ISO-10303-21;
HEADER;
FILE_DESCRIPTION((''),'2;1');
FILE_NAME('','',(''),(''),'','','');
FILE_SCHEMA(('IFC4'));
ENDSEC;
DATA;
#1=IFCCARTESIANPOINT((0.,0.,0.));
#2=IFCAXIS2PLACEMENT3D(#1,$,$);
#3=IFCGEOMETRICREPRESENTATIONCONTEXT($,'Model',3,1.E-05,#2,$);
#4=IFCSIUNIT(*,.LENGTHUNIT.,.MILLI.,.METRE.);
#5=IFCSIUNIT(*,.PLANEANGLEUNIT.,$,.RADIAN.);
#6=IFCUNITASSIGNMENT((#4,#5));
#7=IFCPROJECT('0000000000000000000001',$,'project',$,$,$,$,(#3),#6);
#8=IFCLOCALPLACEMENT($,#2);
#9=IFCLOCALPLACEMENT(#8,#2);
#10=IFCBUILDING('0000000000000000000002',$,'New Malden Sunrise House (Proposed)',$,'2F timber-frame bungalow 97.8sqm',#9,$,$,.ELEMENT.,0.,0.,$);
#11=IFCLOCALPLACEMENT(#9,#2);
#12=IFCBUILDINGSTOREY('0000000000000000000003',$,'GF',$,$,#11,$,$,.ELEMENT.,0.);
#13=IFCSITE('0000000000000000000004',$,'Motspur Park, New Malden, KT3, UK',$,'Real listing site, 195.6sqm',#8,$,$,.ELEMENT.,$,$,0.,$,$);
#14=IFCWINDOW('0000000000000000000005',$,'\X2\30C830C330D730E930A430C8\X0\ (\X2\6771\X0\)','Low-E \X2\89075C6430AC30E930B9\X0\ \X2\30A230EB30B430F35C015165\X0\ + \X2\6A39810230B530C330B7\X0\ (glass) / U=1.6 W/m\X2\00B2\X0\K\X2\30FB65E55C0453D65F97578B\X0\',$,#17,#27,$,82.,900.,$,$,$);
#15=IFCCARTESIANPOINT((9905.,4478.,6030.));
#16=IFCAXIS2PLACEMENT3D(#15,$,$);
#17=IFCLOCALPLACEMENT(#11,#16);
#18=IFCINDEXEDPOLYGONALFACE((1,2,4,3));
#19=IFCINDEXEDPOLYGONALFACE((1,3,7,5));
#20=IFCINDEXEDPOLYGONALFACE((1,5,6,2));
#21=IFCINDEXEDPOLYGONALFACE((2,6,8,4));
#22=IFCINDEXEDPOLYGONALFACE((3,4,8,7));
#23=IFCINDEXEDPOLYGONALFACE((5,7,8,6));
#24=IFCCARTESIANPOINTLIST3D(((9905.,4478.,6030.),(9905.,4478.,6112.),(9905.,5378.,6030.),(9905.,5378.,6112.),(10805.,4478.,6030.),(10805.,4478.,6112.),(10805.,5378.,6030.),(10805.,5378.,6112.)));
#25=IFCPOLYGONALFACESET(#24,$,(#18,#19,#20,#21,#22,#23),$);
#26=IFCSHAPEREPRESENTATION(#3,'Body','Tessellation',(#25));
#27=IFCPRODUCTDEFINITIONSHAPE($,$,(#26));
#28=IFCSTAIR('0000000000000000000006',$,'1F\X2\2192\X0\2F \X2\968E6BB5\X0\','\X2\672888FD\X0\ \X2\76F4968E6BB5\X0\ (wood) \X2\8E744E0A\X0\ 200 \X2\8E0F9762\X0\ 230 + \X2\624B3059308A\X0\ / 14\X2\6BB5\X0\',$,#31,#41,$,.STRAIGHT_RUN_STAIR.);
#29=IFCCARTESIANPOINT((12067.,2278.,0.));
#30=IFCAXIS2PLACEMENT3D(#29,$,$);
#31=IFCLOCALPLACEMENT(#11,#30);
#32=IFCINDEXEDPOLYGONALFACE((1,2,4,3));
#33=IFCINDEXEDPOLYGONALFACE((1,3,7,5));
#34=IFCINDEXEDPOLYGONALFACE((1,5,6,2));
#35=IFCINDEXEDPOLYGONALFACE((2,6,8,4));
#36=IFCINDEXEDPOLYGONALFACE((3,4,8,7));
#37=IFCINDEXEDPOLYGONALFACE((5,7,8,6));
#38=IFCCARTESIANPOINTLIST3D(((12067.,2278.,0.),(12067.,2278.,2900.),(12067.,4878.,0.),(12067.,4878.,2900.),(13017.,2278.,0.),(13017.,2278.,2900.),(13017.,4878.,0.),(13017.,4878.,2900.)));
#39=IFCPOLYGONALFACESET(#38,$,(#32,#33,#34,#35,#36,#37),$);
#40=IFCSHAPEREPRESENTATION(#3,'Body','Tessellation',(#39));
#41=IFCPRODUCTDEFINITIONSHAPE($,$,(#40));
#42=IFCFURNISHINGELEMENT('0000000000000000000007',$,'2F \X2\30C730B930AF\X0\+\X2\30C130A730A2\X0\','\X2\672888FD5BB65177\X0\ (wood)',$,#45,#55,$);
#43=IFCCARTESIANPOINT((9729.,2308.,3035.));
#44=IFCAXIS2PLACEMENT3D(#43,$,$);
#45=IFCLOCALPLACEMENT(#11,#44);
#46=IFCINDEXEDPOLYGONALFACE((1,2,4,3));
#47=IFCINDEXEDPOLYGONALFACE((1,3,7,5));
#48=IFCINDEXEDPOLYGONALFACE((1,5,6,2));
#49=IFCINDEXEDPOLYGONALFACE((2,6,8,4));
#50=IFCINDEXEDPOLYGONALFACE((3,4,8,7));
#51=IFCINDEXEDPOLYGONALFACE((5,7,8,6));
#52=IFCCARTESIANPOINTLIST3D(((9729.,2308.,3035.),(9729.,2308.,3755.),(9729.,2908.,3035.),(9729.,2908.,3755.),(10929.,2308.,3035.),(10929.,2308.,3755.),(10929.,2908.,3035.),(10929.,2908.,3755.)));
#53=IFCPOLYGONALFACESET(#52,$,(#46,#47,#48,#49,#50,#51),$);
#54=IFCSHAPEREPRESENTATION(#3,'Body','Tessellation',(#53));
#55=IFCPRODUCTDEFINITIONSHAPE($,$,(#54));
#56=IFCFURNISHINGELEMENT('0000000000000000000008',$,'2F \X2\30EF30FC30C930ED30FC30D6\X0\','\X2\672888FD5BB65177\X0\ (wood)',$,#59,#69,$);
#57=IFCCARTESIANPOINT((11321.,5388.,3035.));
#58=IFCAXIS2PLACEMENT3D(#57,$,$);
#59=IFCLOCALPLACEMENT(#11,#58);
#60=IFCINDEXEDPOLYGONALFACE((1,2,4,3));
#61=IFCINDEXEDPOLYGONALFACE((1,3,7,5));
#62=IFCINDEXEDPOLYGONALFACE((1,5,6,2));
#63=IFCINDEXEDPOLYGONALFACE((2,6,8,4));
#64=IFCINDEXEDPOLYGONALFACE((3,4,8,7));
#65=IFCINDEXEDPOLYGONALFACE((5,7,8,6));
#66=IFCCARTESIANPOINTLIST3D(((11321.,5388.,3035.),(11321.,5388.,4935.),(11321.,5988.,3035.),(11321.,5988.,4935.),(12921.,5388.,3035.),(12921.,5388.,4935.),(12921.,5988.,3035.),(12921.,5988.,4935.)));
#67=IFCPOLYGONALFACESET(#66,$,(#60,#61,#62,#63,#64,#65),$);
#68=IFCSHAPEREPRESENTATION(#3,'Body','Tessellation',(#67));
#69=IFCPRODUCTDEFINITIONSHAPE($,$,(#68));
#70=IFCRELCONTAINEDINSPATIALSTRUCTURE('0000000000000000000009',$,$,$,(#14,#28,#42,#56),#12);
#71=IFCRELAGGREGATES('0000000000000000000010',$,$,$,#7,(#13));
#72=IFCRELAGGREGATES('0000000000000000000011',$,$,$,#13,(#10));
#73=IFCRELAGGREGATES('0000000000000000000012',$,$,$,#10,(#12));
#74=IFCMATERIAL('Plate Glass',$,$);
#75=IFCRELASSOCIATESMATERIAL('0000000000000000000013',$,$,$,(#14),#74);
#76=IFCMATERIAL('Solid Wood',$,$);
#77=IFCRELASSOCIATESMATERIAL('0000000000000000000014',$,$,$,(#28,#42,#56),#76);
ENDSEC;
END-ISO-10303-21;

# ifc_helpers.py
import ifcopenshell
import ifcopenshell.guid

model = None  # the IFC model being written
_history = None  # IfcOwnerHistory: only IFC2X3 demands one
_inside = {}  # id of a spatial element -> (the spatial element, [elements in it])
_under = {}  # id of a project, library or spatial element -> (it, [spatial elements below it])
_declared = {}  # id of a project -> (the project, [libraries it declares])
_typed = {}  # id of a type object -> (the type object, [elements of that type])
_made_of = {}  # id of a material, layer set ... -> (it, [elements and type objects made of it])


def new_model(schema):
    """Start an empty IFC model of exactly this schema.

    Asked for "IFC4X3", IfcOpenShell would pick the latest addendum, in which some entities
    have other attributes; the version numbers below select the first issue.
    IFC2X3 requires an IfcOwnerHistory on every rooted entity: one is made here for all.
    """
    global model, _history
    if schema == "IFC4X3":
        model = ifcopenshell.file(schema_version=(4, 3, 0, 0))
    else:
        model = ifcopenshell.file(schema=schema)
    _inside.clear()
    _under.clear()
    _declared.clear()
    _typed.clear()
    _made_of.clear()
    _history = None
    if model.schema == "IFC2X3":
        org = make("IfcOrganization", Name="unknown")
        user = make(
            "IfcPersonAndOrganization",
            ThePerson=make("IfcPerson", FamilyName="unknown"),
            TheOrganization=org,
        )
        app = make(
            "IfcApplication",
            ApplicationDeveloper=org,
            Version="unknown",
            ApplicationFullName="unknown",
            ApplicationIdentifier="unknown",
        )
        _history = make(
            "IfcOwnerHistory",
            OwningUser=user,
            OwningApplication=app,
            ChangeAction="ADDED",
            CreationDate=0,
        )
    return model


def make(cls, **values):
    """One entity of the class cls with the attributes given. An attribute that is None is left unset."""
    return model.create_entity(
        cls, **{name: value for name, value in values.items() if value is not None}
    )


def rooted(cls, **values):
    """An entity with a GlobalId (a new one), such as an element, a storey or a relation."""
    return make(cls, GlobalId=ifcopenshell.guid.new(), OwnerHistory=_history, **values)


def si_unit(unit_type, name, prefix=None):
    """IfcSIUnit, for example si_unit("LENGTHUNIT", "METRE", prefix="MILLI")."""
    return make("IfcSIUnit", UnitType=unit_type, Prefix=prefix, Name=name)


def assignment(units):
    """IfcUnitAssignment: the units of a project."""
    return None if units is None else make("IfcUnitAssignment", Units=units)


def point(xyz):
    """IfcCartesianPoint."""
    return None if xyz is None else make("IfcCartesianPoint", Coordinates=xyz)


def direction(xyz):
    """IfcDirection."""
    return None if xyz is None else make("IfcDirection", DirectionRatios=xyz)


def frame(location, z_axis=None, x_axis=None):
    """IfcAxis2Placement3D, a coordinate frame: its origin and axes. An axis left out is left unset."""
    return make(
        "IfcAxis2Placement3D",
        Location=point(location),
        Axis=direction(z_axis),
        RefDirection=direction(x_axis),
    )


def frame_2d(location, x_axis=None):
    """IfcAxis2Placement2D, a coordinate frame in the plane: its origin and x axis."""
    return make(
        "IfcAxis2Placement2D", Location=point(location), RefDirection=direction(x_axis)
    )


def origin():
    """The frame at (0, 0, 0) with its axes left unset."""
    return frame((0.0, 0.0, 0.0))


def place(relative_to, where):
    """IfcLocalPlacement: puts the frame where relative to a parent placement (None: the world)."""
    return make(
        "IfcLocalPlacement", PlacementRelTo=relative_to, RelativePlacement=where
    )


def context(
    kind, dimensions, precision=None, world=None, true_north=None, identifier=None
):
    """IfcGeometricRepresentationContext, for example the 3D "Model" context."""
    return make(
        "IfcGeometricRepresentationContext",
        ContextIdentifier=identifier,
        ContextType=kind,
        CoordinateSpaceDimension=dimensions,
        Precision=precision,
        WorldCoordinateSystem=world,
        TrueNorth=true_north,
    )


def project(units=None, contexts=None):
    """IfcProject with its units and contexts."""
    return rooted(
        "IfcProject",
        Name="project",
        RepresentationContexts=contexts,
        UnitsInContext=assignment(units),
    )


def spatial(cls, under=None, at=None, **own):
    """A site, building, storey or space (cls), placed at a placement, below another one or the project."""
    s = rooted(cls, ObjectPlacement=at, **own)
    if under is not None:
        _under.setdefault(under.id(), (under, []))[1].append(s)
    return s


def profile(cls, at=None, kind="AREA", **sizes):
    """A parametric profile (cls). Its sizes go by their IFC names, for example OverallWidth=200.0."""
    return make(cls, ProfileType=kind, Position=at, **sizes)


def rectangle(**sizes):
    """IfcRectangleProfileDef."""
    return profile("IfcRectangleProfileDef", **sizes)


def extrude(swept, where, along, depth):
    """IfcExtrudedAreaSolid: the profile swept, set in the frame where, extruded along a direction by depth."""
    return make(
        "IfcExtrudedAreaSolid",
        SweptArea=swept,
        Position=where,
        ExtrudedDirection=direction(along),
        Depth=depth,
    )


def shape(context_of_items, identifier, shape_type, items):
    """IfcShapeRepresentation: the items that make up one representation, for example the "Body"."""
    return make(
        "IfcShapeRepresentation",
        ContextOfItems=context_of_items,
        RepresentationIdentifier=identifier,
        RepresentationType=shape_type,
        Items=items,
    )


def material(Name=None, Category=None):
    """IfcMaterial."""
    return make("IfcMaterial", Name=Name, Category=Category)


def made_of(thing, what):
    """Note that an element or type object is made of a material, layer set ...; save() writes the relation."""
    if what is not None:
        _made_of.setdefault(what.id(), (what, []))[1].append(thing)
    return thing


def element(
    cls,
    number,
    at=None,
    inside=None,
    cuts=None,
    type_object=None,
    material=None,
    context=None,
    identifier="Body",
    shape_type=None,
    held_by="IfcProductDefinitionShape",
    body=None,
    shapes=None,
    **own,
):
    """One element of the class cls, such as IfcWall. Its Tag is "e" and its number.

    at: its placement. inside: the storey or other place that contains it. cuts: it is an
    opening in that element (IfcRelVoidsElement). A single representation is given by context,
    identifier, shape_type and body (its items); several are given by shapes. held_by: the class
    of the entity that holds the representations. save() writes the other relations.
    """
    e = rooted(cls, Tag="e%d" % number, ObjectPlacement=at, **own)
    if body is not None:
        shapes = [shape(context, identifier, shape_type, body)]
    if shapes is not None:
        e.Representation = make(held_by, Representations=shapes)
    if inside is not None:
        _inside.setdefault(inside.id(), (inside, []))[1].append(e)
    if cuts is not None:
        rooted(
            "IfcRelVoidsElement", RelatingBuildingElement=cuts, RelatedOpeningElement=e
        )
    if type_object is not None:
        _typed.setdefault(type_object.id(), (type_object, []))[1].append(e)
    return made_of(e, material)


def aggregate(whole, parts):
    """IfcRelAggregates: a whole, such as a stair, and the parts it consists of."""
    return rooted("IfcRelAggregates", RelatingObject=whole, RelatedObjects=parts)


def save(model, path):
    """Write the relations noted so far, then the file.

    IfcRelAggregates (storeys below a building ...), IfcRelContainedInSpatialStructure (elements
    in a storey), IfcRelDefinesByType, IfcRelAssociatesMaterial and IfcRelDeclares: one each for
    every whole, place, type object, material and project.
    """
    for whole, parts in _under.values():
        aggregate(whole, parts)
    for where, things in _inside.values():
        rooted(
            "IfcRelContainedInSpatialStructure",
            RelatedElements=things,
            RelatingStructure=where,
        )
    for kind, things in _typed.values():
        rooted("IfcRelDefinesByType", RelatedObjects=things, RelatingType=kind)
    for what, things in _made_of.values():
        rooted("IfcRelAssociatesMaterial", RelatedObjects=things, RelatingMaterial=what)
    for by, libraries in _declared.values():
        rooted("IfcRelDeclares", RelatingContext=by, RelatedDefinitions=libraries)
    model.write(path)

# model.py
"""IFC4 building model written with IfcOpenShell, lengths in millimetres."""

from ifc_helpers import new_model, si_unit, frame, frame_2d, origin, place, context, project, spatial, rectangle, extrude, material, element, save


model = new_model("IFC4")

# Units and contexts
model_context = context("Model", 3, precision=1e-05, world=origin())
ifc_project = project(units=[si_unit("LENGTHUNIT", "METRE", prefix="MILLI"), si_unit("PLANEANGLEUNIT", "RADIAN")], contexts=[model_context])

# Site, building, storey
site_placement = place(None, origin())
site = spatial("IfcSite", under=ifc_project, at=site_placement, Name="Motspur Park, New Malden, KT3, UK", ObjectType="Real listing site, 195.6sqm", CompositionType="ELEMENT", RefElevation=0.0)
building_placement = place(site_placement, origin())
building = spatial("IfcBuilding", under=site, at=building_placement, Name="New Malden Sunrise House (Proposed)", ObjectType="2F timber-frame bungalow 97.8sqm", CompositionType="ELEMENT", ElevationOfRefHeight=0.0, ElevationOfTerrain=0.0)
storey_placement = place(building_placement, origin())
storey = spatial("IfcBuildingStorey", under=building, at=storey_placement, Name="GF", CompositionType="ELEMENT", Elevation=0.0)

# Shared definitions
ifc_material_1 = material(Name="Solid Wood")

# Shared definitions
ifc_material_2 = material(Name="Plate Glass")

# Window
window_1_placement = place(storey_placement, frame((9905.0, 4478.0, 6030.0)))
element("IfcWindow", 1, at=window_1_placement, inside=storey, material=ifc_material_2, Name="トップライト (東)", Description="Low-E 複層ガラス アルゴン封入 + 樹脂サッシ (glass) / U=1.6 W/m²K・日射取得型", OverallHeight=82.0, OverallWidth=900.0, context=model_context, shape_type="SweptSolid", body=[
    extrude(rectangle(XDim=900.0, YDim=900.0, at=frame_2d((450.0, 450.0))), frame((9905.0, 4478.0, 6030.0)), (0.0, 0.0, 1.0), 82.0),
])

# Stair
stair_placement = place(storey_placement, frame((12067.0, 2278.0, 0.0)))
element("IfcStair", 2, at=stair_placement, inside=storey, material=ifc_material_1, Name="1F→2F 階段", Description="木製 直階段 (wood) 蹴上 200 踏面 230 + 手すり / 14段", PredefinedType="STRAIGHT_RUN_STAIR", context=model_context, shape_type="SweptSolid", body=[
    extrude(rectangle(XDim=950.0, YDim=2600.0, at=frame_2d((475.0, 1300.0))), frame((12067.0, 2278.0, 0.0)), (0.0, 0.0, 1.0), 2900.0),
])

# Furnishing elements
furnishing_1_placement = place(storey_placement, frame((9729.0, 2308.0, 3035.0)))
element("IfcFurnishingElement", 3, at=furnishing_1_placement, inside=storey, material=ifc_material_1, Name="2F デスク+チェア", Description="木製家具 (wood)", context=model_context, shape_type="SweptSolid", body=[
    extrude(rectangle(XDim=1200.0, YDim=600.0, at=frame_2d((600.0, 300.0))), frame((9729.0, 2308.0, 3035.0)), (0.0, 0.0, 1.0), 720.0),
])
furnishing_2_placement = place(storey_placement, frame((11321.0, 5388.0, 3035.0)))
element("IfcFurnishingElement", 4, at=furnishing_2_placement, inside=storey, material=ifc_material_1, Name="2F ワードローブ", Description="木製家具 (wood)", context=model_context, shape_type="SweptSolid", body=[
    extrude(rectangle(XDim=1600.0, YDim=600.0, at=frame_2d((800.0, 300.0))), frame((11321.0, 5388.0, 3035.0)), (0.0, 0.0, 1.0), 1900.0),
])

save(model, "model.ifc")
